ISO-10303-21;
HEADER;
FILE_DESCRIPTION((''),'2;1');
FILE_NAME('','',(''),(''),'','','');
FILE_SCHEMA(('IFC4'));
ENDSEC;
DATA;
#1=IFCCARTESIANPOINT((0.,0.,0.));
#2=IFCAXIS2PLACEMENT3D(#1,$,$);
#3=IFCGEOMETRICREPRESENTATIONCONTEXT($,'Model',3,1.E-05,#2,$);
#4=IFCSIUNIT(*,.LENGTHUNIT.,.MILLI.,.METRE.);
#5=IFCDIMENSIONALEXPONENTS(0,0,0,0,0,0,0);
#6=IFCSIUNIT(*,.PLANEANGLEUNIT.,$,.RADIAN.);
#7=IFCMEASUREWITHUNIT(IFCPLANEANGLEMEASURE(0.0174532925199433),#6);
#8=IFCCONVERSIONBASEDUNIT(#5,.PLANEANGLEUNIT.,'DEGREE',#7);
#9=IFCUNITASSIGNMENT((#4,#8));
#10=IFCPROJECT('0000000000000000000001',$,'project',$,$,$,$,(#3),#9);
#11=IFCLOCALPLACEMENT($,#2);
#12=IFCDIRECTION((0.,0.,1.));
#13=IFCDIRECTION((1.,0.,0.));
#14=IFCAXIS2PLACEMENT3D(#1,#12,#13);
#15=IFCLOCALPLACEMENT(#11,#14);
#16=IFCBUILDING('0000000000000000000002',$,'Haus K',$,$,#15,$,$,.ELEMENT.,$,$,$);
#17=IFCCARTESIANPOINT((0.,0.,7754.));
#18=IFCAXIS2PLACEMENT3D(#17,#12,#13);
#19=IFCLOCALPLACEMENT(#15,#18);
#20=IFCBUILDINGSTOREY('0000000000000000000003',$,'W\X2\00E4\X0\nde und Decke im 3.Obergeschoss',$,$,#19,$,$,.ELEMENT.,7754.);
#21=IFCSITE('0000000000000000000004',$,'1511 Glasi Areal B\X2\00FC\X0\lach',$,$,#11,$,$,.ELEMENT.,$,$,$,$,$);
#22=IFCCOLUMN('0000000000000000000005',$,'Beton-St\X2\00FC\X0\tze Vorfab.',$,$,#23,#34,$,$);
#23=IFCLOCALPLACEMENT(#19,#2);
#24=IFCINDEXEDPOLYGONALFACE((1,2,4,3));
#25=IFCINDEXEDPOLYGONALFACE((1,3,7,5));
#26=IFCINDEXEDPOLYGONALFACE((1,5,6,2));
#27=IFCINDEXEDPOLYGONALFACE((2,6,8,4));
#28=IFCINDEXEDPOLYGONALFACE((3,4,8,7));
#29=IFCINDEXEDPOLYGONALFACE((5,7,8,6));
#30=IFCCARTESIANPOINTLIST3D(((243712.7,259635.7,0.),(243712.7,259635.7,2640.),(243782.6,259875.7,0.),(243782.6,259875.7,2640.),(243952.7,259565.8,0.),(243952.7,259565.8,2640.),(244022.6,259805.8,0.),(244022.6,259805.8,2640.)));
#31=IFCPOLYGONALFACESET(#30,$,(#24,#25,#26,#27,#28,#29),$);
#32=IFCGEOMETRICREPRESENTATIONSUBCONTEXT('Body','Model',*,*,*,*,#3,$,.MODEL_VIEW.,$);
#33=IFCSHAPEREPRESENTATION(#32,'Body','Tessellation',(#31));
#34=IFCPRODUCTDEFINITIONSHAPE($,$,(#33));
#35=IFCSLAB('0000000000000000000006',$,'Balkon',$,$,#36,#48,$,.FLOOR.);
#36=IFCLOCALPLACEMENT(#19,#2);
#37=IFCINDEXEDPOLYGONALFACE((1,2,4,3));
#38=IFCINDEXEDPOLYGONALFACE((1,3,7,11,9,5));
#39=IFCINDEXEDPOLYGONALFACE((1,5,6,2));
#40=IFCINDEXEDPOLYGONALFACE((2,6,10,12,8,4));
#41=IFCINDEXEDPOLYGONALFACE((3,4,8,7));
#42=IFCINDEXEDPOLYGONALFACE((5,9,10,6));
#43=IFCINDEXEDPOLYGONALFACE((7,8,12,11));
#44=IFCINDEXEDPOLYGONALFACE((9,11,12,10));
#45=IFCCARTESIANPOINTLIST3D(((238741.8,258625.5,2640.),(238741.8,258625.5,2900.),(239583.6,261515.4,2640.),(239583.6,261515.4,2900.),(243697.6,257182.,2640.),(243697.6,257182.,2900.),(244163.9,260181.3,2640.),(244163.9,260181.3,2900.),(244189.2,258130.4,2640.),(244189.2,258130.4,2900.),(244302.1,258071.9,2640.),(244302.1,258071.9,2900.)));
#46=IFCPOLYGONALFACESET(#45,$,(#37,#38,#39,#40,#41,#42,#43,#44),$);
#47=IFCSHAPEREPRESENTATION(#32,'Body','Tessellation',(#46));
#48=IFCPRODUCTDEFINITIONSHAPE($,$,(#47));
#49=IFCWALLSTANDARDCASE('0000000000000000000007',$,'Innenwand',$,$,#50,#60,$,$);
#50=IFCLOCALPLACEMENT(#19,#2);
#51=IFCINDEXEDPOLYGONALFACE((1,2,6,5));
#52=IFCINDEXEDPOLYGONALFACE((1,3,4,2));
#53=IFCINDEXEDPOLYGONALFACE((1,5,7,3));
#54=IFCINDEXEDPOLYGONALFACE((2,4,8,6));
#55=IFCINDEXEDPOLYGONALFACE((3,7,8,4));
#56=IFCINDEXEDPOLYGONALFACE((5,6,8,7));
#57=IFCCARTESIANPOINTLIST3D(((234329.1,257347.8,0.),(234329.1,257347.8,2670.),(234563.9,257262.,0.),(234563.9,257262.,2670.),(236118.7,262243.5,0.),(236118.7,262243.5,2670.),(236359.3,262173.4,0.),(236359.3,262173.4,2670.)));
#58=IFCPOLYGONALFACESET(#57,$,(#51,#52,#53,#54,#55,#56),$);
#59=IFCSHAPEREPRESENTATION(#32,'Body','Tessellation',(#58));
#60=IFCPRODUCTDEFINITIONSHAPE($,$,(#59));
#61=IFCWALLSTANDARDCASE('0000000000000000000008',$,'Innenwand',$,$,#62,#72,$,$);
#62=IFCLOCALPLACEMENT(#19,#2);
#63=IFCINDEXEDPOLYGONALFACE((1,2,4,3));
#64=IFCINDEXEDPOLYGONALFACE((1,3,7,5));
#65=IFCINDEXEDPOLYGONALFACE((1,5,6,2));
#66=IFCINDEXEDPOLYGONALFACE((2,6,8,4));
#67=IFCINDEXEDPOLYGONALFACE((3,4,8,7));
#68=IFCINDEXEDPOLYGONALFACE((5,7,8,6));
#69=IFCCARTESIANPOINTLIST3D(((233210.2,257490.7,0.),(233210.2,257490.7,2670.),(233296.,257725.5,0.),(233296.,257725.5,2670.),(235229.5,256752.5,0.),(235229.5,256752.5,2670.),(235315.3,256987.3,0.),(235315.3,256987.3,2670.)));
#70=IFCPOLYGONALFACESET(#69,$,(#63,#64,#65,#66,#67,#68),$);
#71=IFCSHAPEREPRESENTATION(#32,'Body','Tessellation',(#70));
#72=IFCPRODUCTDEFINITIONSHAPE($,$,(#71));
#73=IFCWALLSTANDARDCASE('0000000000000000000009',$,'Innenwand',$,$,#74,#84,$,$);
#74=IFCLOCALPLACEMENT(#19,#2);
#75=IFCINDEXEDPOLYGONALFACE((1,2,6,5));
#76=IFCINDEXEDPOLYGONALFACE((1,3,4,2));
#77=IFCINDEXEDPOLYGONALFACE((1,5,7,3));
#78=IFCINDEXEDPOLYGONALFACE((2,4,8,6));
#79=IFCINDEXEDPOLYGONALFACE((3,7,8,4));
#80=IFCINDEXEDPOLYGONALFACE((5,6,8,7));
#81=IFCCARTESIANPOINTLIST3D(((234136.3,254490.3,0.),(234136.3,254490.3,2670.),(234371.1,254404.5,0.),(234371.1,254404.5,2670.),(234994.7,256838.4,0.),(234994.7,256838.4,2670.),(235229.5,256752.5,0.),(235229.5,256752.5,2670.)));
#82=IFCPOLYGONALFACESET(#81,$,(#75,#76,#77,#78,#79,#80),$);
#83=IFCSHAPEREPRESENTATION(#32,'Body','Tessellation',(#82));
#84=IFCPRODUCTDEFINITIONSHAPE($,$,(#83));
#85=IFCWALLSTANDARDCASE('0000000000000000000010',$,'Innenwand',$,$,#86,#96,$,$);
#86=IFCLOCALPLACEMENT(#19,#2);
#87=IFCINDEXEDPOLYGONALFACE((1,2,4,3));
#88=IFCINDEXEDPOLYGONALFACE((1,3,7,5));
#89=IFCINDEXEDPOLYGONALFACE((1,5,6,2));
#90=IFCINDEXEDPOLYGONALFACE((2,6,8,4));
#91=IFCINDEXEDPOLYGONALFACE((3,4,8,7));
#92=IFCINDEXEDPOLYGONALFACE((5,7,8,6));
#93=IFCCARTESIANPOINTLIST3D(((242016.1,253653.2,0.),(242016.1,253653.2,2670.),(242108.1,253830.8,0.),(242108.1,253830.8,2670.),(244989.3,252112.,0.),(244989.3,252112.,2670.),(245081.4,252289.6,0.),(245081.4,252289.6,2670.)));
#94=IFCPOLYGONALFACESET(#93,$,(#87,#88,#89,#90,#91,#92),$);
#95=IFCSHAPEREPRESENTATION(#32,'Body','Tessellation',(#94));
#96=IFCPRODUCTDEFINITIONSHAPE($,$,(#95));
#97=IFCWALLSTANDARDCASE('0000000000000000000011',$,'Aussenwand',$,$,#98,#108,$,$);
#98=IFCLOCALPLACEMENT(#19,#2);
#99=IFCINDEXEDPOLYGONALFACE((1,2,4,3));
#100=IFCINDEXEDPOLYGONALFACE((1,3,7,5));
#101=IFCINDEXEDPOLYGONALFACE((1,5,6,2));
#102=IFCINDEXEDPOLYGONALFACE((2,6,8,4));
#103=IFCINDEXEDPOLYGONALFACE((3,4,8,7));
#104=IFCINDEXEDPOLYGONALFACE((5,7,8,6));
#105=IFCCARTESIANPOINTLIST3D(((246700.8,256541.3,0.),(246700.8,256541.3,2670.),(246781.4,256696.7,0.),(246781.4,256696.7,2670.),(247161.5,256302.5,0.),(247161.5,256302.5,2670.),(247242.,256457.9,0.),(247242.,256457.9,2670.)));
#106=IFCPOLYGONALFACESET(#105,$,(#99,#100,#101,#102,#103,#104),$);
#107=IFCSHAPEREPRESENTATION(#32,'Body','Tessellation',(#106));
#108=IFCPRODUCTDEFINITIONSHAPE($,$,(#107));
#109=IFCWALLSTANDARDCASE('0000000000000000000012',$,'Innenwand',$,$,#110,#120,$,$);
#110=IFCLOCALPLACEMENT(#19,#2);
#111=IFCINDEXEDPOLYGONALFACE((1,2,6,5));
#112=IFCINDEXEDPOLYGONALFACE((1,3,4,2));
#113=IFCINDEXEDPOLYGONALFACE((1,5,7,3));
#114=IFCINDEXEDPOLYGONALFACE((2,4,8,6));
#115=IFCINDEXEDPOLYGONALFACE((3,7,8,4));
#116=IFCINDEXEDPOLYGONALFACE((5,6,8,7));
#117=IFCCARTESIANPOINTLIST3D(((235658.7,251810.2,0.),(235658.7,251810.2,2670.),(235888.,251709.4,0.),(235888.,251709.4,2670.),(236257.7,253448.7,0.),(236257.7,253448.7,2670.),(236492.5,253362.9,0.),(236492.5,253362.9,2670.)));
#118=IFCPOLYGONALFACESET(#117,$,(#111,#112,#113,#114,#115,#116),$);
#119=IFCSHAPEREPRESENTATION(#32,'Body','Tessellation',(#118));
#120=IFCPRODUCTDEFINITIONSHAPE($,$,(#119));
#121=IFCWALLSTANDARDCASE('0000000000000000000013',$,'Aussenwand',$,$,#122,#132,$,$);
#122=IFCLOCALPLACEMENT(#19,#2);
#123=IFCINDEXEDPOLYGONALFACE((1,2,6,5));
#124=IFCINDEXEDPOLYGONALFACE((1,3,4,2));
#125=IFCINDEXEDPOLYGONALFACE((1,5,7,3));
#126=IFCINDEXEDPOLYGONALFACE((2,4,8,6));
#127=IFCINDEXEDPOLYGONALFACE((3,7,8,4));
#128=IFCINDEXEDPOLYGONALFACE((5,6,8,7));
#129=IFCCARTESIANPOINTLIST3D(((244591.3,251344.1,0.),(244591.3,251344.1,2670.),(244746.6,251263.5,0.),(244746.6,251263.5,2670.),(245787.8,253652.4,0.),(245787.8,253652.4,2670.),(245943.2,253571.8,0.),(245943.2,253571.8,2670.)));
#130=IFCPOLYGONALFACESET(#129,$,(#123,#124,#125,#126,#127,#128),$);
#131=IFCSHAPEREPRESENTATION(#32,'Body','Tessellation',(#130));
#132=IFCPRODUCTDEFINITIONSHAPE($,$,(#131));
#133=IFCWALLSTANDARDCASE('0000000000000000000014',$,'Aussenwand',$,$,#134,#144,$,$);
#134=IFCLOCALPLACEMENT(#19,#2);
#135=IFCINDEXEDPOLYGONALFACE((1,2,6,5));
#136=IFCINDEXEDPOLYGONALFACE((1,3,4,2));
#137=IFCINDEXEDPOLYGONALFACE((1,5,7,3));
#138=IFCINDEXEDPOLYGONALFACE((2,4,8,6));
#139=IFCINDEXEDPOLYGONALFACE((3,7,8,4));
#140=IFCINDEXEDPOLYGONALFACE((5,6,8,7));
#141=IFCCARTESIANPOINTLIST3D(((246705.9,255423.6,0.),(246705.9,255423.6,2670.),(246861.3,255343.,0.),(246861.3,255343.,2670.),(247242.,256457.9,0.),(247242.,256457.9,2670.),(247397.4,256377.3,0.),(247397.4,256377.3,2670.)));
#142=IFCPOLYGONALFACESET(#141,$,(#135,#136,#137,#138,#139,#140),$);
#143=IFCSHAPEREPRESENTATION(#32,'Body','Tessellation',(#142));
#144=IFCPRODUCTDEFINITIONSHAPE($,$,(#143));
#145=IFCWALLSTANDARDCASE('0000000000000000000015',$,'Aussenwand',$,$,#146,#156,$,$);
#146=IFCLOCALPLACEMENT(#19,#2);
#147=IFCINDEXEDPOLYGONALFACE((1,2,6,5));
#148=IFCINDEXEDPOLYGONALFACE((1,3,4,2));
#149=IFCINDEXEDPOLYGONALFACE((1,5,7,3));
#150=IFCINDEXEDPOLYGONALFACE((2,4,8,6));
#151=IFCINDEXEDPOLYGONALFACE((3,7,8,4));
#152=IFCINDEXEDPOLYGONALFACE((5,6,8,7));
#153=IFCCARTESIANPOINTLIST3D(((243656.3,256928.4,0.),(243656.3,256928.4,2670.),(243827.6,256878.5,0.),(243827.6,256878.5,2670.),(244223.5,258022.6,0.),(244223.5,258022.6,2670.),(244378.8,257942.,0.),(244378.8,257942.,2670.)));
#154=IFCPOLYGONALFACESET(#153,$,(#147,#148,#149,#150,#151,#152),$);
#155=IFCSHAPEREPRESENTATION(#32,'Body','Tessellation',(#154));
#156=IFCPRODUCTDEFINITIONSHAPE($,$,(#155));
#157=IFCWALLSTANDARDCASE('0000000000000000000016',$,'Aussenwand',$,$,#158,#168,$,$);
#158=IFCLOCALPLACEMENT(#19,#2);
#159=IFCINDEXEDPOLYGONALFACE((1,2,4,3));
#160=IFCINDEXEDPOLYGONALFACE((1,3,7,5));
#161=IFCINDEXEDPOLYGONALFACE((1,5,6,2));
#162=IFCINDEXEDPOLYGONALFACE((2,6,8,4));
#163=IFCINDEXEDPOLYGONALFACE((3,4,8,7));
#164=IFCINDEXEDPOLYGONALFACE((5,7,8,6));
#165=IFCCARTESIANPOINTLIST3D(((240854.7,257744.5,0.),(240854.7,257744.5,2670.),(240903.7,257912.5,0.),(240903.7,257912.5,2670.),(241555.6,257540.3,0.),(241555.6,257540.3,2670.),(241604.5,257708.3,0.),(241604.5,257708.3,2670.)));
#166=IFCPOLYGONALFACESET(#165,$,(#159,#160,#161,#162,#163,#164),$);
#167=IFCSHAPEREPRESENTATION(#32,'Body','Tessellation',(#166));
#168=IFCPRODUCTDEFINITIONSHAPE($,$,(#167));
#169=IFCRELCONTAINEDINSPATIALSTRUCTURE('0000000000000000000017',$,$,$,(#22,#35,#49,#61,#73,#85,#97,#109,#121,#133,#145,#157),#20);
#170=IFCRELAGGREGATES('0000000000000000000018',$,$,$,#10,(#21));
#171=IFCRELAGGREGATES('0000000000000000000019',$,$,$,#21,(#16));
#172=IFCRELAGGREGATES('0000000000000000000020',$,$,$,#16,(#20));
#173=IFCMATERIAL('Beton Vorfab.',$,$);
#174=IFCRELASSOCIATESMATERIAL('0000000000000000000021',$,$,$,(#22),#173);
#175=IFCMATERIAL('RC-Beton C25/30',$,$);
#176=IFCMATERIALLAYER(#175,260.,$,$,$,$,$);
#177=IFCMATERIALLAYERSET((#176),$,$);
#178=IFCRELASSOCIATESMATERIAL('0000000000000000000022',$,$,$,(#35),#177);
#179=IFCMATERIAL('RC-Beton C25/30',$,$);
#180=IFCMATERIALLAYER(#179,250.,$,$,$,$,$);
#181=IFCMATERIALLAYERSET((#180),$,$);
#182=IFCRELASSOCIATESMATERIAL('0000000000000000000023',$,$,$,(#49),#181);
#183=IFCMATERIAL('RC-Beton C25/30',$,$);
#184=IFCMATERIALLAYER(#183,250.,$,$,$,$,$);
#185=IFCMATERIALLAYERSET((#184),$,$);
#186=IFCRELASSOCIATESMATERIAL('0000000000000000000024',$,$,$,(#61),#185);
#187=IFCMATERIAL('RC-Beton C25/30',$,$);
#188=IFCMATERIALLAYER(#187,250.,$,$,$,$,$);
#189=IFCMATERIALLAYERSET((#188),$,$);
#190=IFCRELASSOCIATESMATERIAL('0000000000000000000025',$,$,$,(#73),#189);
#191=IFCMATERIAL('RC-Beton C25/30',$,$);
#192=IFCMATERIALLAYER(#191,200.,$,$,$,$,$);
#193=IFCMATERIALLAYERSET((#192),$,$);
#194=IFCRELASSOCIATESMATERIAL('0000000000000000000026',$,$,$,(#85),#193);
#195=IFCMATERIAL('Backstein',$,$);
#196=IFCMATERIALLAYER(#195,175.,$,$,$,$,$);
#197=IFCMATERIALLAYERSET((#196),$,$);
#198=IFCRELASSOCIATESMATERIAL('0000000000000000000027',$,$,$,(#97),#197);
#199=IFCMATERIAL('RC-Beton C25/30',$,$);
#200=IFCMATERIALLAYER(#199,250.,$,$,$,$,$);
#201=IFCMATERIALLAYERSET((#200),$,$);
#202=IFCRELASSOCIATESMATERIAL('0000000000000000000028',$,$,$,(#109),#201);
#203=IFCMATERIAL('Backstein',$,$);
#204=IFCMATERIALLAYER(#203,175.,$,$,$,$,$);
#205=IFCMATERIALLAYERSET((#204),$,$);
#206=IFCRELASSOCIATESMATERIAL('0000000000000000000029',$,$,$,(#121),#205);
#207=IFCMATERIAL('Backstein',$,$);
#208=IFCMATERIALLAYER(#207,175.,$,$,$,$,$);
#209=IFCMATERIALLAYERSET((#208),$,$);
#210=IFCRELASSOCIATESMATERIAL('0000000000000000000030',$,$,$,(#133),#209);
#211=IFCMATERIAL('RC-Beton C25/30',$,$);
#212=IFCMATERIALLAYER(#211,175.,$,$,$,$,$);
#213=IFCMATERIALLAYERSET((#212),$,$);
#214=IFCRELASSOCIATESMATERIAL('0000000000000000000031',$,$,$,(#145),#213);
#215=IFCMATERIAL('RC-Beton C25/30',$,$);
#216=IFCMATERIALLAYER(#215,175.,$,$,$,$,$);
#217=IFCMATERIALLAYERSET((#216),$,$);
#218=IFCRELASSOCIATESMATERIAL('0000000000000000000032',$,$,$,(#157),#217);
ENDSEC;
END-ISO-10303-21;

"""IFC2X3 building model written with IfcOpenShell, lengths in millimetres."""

from ifc_helpers import new_model, entity, si_unit, converted_unit, frame, frame_2d, origin, origin_with_axes, place, context, subcontext, project, spatial, polyline, rectangle, outline, extrude, material, layer, layer_set, layer_usage, element, save


model = new_model("IFC2X3")

# Units and contexts
model_context = context("Model", 3, precision=1e-05, world=origin())
body_context = subcontext(model_context, "Body", "Model", "MODEL_VIEW")
ifc_project = project(units=[si_unit("LENGTHUNIT", "METRE", prefix="MILLI"), converted_unit("PLANEANGLEUNIT", "DEGREE", entity("IfcPlaneAngleMeasure", 0.0174532925199433), si_unit("PLANEANGLEUNIT", "RADIAN"), dimensions=[0, 0, 0, 0, 0, 0, 0])], contexts=[model_context])

# Site, building, storey
site_placement = place(None, origin())
site = spatial("IfcSite", under=ifc_project, at=site_placement, Name="1511 Glasi Areal Bülach", CompositionType="ELEMENT")
building_placement = place(site_placement, origin_with_axes())
building = spatial("IfcBuilding", under=site, at=building_placement, Name="Haus K", CompositionType="ELEMENT")
storey_placement = place(building_placement, frame((0.0, 0.0, 7754.0), z_axis=(0.0, 0.0, 1.0), x_axis=(1.0, 0.0, 0.0)))
storey = spatial("IfcBuildingStorey", under=building, at=storey_placement, Name="Wände und Decke im 3.Obergeschoss", CompositionType="ELEMENT", Elevation=7754.0)

# Column
ifc_material_1 = material(Name="Beton Vorfab.")
column_placement = place(storey_placement, frame((243712.7, 259635.7, 0.0), z_axis=(0.0, 0.0, 1.0), x_axis=(1.0, 0.0, 0.0)))
element("IfcColumn", 1, at=column_placement, inside=storey, material=ifc_material_1, Name="Beton-Stütze Vorfab.", context=body_context, shape_type="SweptSolid", body=[
    extrude(rectangle(XDim=250.0, YDim=250.0, at=frame_2d((155.0, 85.1), x_axis=(0.960099, -0.279661))), origin_with_axes(), (0.0, 0.0, 1.0), 2640.0),
])

# Slab
ifc_material_2 = material(Name="RC-Beton C25/30")
ifc_layer_1 = layer(ifc_material_2, 260.0)
ifc_layer_set_1 = layer_set([ifc_layer_1])
ifc_layer_usage_1 = layer_usage(ifc_layer_set_1, "AXIS3", "POSITIVE", 0.0)
slab_placement = place(storey_placement, frame((238741.8, 257182.0, 2640.0), z_axis=(0.0, 0.0, 1.0), x_axis=(1.0, 0.0, 0.0)))
element("IfcSlab", 2, at=slab_placement, inside=storey, material=ifc_layer_usage_1, Name="Balkon", PredefinedType="FLOOR", context=body_context, shape_type="SweptSolid", body=[
    extrude(outline(polyline([(841.8, 4333.4), (0.0, 1443.5), (4955.8, 0.0), (5447.4, 948.4), (5560.3, 889.9), (5422.0, 2999.3), (841.8, 4333.4)])), origin_with_axes(), (0.0, 0.0, 1.0), 260.0),
])

# Walls
ifc_material_3 = material(Name="RC-Beton C25/30")
ifc_layer_2 = layer(ifc_material_3, 250.0)
ifc_layer_set_2 = layer_set([ifc_layer_2])
ifc_layer_usage_2 = layer_usage(ifc_layer_set_2, "AXIS2", "POSITIVE", 0.0)
wall_1_placement = place(storey_placement, frame((234563.9, 257262.0, 0.0), z_axis=(0.0, 0.0, 1.0), x_axis=(0.343332, 0.939214, 0.0)))
element("IfcWallStandardCase", 3, at=wall_1_placement, inside=storey, material=ifc_layer_usage_2, Name="Innenwand", context=body_context, shape_type="SweptSolid", body=[
    extrude(outline(polyline([(0.0, 0.0), (5229.2, 0.0), (5212.5, 250.0), (0.0, 250.0), (0.0, 0.0)])), origin_with_axes(), (0.0, 0.0, 1.0), 2670.0),
])
ifc_material_4 = material(Name="RC-Beton C25/30")
ifc_layer_3 = layer(ifc_material_4, 250.0)
ifc_layer_set_3 = layer_set([ifc_layer_3])
ifc_layer_usage_3 = layer_usage(ifc_layer_set_3, "AXIS2", "POSITIVE", 0.0)
wall_2_placement = place(storey_placement, frame((235315.3, 256987.3, 0.0), z_axis=(0.0, 0.0, 1.0), x_axis=(-0.939214, 0.343332, 0.0)))
element("IfcWallStandardCase", 4, at=wall_2_placement, inside=storey, material=ifc_layer_usage_3, Name="Innenwand", context=body_context, shape_type="SweptSolid", body=[
    extrude(rectangle(XDim=2150.0, YDim=250.0, at=frame_2d((1075.0, 125.0), x_axis=(1.0, 0.0))), origin_with_axes(), (0.0, 0.0, 1.0), 2670.0),
])
ifc_material_5 = material(Name="RC-Beton C25/30")
ifc_layer_4 = layer(ifc_material_5, 250.0)
ifc_layer_set_4 = layer_set([ifc_layer_4])
ifc_layer_usage_4 = layer_usage(ifc_layer_set_4, "AXIS2", "POSITIVE", 0.0)
wall_3_placement = place(storey_placement, frame((234371.1, 254404.5, 0.0), z_axis=(0.0, 0.0, 1.0), x_axis=(0.343332, 0.939214, 0.0)))
element("IfcWallStandardCase", 5, at=wall_3_placement, inside=storey, material=ifc_layer_usage_4, Name="Innenwand", context=body_context, shape_type="SweptSolid", body=[
    extrude(rectangle(XDim=2500.0, YDim=250.0, at=frame_2d((1250.0, 125.0), x_axis=(1.0, 0.0))), origin_with_axes(), (0.0, 0.0, 1.0), 2670.0),
])
ifc_material_6 = material(Name="RC-Beton C25/30")
ifc_layer_5 = layer(ifc_material_6, 200.0)
ifc_layer_set_5 = layer_set([ifc_layer_5])
ifc_layer_usage_5 = layer_usage(ifc_layer_set_5, "AXIS2", "POSITIVE", 0.0)
wall_4_placement = place(storey_placement, frame((245081.4, 252289.6, 0.0), z_axis=(0.0, 0.0, 1.0), x_axis=(-0.887815, 0.4602, 0.0)))
element("IfcWallStandardCase", 6, at=wall_4_placement, inside=storey, material=ifc_layer_usage_5, Name="Innenwand", context=body_context, shape_type="SweptSolid", body=[
    extrude(rectangle(XDim=3349.0, YDim=200.0, at=frame_2d((1674.5, 100.0), x_axis=(1.0, 0.0))), origin_with_axes(), (0.0, 0.0, 1.0), 2670.0),
])
ifc_material_7 = material(Name="Backstein")
ifc_layer_6 = layer(ifc_material_7, 175.0)
ifc_layer_set_6 = layer_set([ifc_layer_6])
ifc_layer_usage_6 = layer_usage(ifc_layer_set_6, "AXIS2", "POSITIVE", 0.0)
wall_5_placement = place(storey_placement, frame((247242.0, 256457.9, 0.0), z_axis=(0.0, 0.0, 1.0), x_axis=(-0.887815, 0.4602, 0.0)))
element("IfcWallStandardCase", 7, at=wall_5_placement, inside=storey, material=ifc_layer_usage_6, Name="Aussenwand", context=body_context, shape_type="SweptSolid", body=[
    extrude(outline(polyline([(0.0, 0.0), (518.9, 0.0), (518.9, 175.0), (0.0, 175.0), (0.0, 0.0)])), origin_with_axes(), (0.0, 0.0, 1.0), 2670.0),
])
ifc_material_8 = material(Name="RC-Beton C25/30")
ifc_layer_7 = layer(ifc_material_8, 250.0)
ifc_layer_set_7 = layer_set([ifc_layer_7])
ifc_layer_usage_7 = layer_usage(ifc_layer_set_7, "AXIS2", "POSITIVE", 0.0)
wall_6_placement = place(storey_placement, frame((236257.7, 253448.7, 0.0), z_axis=(0.0, 0.0, 1.0), x_axis=(-0.343332, -0.939214, 0.0)))
element("IfcWallStandardCase", 8, at=wall_6_placement, inside=storey, material=ifc_layer_usage_7, Name="Innenwand", context=body_context, shape_type="SweptSolid", body=[
    extrude(outline(polyline([(0.0, 0.0), (1744.5, 0.0), (1760.5, 250.0), (0.0, 250.0), (0.0, 0.0)])), origin_with_axes(), (0.0, 0.0, 1.0), 2670.0),
])
ifc_material_9 = material(Name="Backstein")
ifc_layer_8 = layer(ifc_material_9, 175.0)
ifc_layer_set_8 = layer_set([ifc_layer_8])
ifc_layer_usage_8 = layer_usage(ifc_layer_set_8, "AXIS2", "POSITIVE", 0.0)
wall_7_placement = place(storey_placement, frame((244746.6, 251263.5, 0.0), z_axis=(0.0, 0.0, 1.0), x_axis=(0.4602, 0.887815, 0.0)))
element("IfcWallStandardCase", 9, at=wall_7_placement, inside=storey, material=ifc_layer_usage_8, Name="Aussenwand", context=body_context, shape_type="SweptSolid", body=[
    extrude(rectangle(XDim=2600.0, YDim=175.0, at=frame_2d((1300.0, 87.5), x_axis=(1.0, 0.0))), origin_with_axes(), (0.0, 0.0, 1.0), 2670.0),
])
ifc_material_10 = material(Name="Backstein")
ifc_layer_9 = layer(ifc_material_10, 175.0)
ifc_layer_set_9 = layer_set([ifc_layer_9])
ifc_layer_usage_9 = layer_usage(ifc_layer_set_9, "AXIS2", "POSITIVE", 0.0)
wall_8_placement = place(storey_placement, frame((246861.3, 255343.0, 0.0), z_axis=(0.0, 0.0, 1.0), x_axis=(0.4602, 0.887815, 0.0)))
element("IfcWallStandardCase", 10, at=wall_8_placement, inside=storey, material=ifc_layer_usage_9, Name="Aussenwand", context=body_context, shape_type="SweptSolid", body=[
    extrude(rectangle(XDim=1165.0, YDim=175.0, at=frame_2d((582.5, 87.5), x_axis=(1.0, 0.0))), origin_with_axes(), (0.0, 0.0, 1.0), 2670.0),
])
ifc_material_11 = material(Name="RC-Beton C25/30")
ifc_layer_10 = layer(ifc_material_11, 175.0)
ifc_layer_set_10 = layer_set([ifc_layer_10])
ifc_layer_usage_10 = layer_usage(ifc_layer_set_10, "AXIS2", "POSITIVE", 0.0)
wall_9_placement = place(storey_placement, frame((244223.5, 258022.6, 0.0), z_axis=(0.0, 0.0, 1.0), x_axis=(-0.4602, -0.887815, 0.0)))
element("IfcWallStandardCase", 11, at=wall_9_placement, inside=storey, material=ifc_layer_usage_10, Name="Aussenwand", context=body_context, shape_type="SweptSolid", body=[
    extrude(outline(polyline([(0.0, 0.0), (1232.4, 0.0), (1197.9, 175.0), (0.0, 175.0), (0.0, 0.0)])), origin_with_axes(), (0.0, 0.0, 1.0), 2670.0),
])
ifc_material_12 = material(Name="RC-Beton C25/30")
ifc_layer_11 = layer(ifc_material_12, 175.0)
ifc_layer_set_11 = layer_set([ifc_layer_11])
ifc_layer_usage_11 = layer_usage(ifc_layer_set_11, "AXIS2", "POSITIVE", 0.0)
wall_10_placement = place(storey_placement, frame((241604.5, 257708.3, 0.0), z_axis=(0.0, 0.0, 1.0), x_axis=(-0.960099, 0.279661, 0.0)))
element("IfcWallStandardCase", 12, at=wall_10_placement, inside=storey, material=ifc_layer_usage_11, Name="Aussenwand", context=body_context, shape_type="SweptSolid", body=[
    extrude(rectangle(XDim=730.0, YDim=175.0, at=frame_2d((365.0, 87.5), x_axis=(1.0, 0.0))), origin_with_axes(), (0.0, 0.0, 1.0), 2670.0),
])

save(model, "model.ifc")
